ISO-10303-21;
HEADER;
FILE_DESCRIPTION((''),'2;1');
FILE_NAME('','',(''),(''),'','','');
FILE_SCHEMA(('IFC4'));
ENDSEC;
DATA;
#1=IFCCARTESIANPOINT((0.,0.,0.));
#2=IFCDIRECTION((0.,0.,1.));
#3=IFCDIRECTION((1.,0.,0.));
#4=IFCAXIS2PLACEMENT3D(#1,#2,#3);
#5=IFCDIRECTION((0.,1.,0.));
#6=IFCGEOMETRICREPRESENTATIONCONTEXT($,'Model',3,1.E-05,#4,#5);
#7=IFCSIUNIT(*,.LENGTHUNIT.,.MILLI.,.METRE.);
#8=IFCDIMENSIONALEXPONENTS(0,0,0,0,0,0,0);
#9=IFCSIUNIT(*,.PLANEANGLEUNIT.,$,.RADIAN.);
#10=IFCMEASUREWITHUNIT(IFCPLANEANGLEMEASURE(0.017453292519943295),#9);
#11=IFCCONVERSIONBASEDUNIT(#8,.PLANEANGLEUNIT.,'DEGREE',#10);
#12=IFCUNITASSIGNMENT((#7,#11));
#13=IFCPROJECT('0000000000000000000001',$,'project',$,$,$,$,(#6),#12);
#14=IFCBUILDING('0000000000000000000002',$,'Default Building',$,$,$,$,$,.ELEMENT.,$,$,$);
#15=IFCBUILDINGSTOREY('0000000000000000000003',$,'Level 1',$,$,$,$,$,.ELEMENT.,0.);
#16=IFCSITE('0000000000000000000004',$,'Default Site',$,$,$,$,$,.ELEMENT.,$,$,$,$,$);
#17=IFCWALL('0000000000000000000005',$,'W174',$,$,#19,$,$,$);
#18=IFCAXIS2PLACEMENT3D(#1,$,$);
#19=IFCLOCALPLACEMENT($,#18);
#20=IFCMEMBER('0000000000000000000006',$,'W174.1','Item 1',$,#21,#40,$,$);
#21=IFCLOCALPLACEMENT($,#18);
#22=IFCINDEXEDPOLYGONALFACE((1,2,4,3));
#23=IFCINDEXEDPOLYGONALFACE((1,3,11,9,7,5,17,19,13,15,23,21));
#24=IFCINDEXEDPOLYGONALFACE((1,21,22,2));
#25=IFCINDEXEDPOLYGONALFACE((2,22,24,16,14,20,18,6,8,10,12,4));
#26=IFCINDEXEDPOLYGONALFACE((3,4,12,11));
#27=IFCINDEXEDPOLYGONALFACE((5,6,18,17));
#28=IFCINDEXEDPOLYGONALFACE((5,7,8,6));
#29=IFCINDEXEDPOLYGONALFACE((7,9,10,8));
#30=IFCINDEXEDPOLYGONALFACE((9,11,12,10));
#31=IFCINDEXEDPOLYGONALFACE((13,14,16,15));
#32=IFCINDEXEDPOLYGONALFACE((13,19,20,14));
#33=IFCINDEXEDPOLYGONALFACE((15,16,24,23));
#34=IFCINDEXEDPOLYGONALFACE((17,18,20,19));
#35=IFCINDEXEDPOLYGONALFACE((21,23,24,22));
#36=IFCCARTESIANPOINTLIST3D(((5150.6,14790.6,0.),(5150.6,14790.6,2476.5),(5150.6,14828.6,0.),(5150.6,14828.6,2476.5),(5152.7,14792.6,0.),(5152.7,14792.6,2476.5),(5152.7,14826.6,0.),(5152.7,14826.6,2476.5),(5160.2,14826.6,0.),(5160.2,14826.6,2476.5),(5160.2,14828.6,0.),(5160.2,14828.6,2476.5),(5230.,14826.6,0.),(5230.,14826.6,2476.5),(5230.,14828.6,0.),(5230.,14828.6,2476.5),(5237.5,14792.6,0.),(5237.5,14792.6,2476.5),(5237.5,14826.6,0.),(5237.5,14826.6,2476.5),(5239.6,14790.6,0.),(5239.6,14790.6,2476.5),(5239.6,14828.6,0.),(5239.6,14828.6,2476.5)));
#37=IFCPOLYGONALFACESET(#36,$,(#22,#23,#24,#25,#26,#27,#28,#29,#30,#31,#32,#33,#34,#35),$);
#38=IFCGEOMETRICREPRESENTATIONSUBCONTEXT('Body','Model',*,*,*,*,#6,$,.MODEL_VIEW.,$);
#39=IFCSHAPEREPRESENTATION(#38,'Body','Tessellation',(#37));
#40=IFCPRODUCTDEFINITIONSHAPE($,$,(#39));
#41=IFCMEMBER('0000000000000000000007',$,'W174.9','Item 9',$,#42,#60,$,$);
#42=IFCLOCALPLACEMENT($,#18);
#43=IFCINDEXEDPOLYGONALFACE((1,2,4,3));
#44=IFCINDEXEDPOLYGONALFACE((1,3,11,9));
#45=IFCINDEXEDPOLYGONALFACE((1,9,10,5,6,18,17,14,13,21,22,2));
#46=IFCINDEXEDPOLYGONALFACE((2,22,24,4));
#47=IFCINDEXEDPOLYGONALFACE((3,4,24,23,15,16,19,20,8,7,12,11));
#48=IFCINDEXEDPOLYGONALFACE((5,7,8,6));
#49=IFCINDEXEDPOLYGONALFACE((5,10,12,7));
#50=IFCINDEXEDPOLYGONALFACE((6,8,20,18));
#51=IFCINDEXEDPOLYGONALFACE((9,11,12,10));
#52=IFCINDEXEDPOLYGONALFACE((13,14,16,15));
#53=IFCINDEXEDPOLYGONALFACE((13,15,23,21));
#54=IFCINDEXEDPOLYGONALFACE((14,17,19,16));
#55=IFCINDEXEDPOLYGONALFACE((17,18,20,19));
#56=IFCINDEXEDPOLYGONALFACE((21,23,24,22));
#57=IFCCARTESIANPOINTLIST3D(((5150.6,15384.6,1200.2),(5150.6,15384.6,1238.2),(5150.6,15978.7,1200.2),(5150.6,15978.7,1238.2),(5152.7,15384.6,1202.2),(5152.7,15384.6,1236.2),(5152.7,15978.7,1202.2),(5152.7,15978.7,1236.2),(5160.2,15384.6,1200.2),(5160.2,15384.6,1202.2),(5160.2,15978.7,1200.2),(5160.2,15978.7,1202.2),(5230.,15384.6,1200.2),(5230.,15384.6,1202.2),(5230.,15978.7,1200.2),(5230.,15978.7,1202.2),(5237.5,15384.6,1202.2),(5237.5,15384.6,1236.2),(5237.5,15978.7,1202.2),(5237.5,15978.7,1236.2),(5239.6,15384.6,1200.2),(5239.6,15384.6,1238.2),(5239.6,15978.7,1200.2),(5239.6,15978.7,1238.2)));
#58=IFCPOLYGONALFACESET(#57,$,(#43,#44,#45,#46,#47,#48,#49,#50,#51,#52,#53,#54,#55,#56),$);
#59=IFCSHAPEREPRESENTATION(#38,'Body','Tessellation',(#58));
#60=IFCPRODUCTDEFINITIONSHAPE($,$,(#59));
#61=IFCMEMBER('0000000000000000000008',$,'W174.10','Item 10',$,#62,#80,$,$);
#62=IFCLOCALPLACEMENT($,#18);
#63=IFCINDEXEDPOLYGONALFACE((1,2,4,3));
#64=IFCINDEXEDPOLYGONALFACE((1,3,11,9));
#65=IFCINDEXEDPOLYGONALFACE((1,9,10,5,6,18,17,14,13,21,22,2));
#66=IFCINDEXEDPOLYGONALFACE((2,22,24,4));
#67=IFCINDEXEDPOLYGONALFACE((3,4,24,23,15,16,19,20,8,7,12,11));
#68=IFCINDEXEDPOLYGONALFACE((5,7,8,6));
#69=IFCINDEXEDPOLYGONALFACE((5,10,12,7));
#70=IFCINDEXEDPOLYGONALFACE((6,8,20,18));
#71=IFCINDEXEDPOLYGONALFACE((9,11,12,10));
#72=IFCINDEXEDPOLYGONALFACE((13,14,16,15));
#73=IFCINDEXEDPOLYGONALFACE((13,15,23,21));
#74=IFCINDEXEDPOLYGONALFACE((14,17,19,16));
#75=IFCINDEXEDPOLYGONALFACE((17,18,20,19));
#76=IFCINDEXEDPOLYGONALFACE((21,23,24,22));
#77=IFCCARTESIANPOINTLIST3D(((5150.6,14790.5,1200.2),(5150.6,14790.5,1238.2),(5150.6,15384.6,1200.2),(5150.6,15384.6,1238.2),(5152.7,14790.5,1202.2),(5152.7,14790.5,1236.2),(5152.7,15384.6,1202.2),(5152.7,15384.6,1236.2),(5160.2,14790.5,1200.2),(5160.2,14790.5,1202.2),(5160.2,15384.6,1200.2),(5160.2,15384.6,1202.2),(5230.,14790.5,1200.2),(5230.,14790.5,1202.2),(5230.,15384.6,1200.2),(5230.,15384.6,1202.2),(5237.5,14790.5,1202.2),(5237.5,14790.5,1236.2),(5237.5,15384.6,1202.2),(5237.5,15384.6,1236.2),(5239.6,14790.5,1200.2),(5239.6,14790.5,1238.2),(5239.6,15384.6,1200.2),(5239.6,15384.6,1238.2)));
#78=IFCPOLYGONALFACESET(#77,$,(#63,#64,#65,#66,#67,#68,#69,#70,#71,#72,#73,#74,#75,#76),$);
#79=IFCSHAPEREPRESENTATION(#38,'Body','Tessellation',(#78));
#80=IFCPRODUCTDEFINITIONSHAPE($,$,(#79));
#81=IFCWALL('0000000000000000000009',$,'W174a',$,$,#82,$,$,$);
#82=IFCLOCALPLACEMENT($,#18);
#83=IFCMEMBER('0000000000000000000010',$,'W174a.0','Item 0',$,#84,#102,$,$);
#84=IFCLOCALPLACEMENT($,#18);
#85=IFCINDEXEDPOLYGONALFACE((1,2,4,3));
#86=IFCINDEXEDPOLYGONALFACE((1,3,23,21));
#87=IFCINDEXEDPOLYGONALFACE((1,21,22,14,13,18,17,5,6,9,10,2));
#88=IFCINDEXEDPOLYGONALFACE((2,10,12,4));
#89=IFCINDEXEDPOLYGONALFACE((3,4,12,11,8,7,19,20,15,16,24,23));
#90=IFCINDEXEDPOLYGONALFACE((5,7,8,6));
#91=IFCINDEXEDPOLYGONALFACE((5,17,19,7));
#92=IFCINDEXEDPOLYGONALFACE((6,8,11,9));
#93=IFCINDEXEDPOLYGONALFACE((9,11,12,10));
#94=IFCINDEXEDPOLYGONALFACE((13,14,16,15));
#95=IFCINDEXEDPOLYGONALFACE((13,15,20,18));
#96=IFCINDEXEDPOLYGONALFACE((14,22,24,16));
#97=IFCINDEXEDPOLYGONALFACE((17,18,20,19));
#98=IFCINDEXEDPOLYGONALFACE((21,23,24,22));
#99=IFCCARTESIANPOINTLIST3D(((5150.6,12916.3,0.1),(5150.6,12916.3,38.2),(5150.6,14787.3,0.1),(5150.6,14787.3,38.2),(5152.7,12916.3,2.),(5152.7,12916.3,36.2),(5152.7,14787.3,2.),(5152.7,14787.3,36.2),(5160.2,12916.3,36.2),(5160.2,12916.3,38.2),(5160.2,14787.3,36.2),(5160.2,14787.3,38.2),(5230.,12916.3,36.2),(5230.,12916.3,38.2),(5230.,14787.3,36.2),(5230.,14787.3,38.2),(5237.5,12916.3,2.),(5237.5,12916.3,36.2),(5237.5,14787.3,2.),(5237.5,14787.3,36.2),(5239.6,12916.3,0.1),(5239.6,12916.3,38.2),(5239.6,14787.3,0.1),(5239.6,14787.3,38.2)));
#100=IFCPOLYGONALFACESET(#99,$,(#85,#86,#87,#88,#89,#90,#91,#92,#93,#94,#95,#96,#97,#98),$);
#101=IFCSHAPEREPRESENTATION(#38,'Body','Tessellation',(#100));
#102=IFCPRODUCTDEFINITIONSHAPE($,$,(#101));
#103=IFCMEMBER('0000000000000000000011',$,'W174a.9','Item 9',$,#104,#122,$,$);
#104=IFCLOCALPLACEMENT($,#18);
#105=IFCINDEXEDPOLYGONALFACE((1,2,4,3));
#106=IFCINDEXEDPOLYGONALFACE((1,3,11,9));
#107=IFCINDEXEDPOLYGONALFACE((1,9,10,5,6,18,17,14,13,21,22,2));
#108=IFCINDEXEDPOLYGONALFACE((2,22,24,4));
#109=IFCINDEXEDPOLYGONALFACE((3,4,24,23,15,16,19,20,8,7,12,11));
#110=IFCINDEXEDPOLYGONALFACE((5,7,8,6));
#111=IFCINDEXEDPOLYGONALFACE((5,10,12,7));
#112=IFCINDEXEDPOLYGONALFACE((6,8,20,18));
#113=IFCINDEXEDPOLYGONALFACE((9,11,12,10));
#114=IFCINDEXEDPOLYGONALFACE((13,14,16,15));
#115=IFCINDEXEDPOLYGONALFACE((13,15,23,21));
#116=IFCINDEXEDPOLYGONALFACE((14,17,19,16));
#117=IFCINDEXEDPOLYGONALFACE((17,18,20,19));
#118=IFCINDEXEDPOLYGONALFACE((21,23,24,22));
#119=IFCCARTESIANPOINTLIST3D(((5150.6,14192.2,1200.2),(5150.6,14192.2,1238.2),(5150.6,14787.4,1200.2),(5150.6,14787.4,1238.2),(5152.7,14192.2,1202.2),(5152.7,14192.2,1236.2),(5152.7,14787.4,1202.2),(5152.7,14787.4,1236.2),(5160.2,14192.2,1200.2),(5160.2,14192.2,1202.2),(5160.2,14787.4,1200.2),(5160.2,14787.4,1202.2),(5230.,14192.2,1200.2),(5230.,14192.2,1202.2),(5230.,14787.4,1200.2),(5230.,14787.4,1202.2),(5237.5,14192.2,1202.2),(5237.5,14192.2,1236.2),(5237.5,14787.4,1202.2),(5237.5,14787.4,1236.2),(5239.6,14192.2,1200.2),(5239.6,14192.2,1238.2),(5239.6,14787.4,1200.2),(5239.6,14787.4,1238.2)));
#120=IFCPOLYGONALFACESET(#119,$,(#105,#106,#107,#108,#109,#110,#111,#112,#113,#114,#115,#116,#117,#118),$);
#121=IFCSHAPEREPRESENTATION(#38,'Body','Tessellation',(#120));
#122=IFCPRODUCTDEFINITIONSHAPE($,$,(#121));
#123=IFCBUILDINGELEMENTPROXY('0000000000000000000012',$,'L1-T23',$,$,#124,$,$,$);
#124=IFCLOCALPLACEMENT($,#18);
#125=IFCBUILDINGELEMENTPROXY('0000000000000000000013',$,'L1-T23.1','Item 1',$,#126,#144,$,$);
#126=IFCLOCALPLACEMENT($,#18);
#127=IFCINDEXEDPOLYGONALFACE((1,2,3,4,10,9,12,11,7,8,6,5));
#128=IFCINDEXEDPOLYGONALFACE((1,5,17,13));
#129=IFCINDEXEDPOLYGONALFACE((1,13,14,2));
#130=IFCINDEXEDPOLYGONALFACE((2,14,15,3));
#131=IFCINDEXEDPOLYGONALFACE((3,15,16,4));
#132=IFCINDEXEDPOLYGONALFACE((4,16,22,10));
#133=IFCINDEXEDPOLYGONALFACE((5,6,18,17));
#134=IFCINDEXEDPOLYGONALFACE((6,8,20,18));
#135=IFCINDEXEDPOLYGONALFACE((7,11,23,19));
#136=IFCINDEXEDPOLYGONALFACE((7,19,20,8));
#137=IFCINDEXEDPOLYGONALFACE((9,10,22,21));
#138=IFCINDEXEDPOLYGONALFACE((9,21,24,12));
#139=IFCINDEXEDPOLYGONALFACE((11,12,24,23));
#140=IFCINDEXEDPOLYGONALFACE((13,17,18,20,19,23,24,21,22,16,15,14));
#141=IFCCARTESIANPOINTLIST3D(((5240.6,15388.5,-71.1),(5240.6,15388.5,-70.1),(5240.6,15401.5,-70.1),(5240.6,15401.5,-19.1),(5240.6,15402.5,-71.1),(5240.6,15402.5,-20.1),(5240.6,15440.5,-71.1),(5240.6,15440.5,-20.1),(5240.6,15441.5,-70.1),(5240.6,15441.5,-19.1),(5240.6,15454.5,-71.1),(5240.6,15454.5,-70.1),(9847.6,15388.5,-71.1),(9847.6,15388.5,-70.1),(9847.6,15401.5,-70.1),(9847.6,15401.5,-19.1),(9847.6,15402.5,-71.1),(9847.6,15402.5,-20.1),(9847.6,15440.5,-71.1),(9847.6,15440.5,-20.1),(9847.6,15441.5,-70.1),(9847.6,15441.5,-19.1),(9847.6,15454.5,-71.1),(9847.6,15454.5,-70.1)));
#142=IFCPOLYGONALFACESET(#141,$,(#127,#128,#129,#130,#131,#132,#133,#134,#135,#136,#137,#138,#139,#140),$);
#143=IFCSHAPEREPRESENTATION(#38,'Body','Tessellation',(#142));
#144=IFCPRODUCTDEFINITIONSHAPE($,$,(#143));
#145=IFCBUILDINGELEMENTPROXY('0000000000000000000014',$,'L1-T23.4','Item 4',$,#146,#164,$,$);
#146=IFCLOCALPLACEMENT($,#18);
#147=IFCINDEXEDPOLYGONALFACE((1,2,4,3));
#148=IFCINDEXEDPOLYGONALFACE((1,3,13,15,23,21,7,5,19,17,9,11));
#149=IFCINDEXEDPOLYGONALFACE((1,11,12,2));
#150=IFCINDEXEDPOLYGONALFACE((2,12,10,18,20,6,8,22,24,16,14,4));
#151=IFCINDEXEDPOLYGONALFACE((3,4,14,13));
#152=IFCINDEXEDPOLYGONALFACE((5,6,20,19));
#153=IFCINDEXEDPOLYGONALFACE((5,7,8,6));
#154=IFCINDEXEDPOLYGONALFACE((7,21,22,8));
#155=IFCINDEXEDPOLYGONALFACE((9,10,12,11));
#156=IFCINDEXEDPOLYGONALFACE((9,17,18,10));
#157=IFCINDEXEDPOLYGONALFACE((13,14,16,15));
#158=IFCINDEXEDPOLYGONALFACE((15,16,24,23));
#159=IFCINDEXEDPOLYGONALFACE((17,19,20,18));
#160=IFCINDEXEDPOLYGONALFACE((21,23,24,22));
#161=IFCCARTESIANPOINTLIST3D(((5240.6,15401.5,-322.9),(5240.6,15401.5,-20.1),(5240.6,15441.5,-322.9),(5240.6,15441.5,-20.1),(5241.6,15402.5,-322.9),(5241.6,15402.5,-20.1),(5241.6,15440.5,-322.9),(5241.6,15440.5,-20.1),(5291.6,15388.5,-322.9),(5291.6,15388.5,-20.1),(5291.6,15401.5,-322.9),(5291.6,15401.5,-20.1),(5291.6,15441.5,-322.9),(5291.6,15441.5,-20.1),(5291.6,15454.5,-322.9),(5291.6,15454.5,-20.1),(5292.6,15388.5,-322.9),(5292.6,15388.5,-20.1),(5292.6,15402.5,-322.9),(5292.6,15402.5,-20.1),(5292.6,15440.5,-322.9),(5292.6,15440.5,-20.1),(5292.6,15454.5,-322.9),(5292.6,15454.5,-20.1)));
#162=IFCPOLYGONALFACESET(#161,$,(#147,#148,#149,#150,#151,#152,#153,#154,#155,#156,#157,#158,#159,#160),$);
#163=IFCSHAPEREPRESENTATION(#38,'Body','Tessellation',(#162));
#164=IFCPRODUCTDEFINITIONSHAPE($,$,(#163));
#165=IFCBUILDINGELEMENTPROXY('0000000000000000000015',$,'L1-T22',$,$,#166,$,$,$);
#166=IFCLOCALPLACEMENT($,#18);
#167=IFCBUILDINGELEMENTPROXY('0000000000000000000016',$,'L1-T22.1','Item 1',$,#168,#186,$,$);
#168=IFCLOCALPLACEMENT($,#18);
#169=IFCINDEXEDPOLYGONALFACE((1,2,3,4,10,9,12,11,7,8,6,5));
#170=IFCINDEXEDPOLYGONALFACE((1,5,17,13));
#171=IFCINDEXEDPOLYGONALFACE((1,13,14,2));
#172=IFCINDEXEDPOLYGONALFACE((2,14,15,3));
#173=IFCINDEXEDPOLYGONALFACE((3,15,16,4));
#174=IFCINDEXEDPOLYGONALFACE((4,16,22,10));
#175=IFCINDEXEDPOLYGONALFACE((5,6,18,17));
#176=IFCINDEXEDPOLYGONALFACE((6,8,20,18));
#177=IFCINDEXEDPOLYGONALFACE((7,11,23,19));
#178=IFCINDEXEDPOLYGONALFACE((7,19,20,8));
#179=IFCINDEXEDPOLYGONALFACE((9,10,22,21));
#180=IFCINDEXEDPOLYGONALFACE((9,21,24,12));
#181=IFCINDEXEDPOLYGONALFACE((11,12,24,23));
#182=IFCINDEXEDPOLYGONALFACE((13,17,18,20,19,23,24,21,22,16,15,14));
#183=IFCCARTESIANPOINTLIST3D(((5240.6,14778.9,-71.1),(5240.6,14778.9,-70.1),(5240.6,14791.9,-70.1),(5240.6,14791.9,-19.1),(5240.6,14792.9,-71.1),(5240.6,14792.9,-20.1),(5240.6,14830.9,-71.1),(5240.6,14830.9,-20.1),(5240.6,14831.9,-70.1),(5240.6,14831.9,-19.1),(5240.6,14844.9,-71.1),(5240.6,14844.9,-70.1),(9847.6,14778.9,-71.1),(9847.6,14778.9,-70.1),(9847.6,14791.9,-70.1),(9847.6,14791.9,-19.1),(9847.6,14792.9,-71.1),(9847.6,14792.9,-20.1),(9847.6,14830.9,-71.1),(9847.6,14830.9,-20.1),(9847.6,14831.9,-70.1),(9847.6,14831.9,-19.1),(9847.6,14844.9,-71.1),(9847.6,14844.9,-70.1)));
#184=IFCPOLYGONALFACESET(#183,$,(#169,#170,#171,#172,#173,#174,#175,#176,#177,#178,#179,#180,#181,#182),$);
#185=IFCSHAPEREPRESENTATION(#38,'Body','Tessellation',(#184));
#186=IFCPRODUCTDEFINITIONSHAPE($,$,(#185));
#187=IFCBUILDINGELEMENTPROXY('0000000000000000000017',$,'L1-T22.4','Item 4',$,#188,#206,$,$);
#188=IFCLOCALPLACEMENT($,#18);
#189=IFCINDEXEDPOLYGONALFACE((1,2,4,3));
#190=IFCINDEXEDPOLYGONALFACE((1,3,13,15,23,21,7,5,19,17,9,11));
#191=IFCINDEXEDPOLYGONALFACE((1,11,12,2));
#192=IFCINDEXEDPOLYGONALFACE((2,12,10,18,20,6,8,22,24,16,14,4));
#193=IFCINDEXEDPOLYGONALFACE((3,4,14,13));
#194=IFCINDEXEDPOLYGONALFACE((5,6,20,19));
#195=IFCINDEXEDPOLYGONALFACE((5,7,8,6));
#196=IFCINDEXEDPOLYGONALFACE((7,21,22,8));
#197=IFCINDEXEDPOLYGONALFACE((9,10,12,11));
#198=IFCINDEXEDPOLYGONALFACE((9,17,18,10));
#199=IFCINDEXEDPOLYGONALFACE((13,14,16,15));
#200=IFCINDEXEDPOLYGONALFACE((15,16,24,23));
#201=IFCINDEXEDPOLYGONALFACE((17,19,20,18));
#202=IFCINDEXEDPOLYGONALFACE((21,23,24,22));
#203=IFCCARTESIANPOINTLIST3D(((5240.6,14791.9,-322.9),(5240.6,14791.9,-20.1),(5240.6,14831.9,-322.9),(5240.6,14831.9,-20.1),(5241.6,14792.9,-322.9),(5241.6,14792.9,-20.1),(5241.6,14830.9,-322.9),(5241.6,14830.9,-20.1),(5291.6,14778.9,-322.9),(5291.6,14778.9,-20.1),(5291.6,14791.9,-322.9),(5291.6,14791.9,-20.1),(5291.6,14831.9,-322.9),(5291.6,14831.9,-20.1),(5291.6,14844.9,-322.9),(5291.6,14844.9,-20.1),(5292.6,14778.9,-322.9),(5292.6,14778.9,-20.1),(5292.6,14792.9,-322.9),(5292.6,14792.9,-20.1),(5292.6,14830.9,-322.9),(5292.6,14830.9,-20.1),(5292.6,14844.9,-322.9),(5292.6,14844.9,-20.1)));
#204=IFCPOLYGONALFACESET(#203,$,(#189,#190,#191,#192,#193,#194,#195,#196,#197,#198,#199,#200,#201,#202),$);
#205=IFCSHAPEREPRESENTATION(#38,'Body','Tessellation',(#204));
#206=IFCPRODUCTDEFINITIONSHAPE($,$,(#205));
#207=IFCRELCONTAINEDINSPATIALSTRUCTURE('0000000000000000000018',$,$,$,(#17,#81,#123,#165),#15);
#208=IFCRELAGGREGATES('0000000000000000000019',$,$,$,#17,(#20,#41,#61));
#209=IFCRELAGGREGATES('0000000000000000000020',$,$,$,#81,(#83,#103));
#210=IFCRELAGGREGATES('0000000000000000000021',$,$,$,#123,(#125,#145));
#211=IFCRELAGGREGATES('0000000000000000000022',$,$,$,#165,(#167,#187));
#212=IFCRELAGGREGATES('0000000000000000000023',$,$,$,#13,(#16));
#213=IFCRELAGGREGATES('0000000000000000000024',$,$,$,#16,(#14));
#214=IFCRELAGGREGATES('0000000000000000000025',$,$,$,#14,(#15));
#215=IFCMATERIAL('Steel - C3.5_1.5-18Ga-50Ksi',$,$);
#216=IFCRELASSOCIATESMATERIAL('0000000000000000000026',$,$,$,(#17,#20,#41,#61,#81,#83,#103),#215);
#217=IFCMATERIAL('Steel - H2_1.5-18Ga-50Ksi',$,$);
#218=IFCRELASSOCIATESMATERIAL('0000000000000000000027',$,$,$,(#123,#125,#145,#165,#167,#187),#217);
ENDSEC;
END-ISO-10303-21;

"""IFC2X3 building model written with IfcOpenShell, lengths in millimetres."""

from ifc_helpers import new_model, entity, si_unit, converted_unit, direction, frame, origin, origin_with_axes, origin_2d_with_axis, place, context, subcontext, project, spatial, polyline, c_section, outline, extrude, material, element, aggregate, save


model = new_model("IFC2X3")

# Units and contexts
model_context = context("Model", 3, precision=1e-05, world=origin_with_axes(), true_north=direction((0.0, 1.0, 0.0)))
body_context = subcontext(model_context, "Body", "Model", "MODEL_VIEW")
ifc_project = project(units=[si_unit("LENGTHUNIT", "METRE", prefix="MILLI"), converted_unit("PLANEANGLEUNIT", "DEGREE", entity("IfcPlaneAngleMeasure", 0.017453292519943295), si_unit("PLANEANGLEUNIT", "RADIAN"), dimensions=[0, 0, 0, 0, 0, 0, 0])], contexts=[model_context])

# Site, building, storey
site = spatial("IfcSite", under=ifc_project, Name="Default Site", CompositionType="ELEMENT")
building = spatial("IfcBuilding", under=site, Name="Default Building", CompositionType="ELEMENT")
storey = spatial("IfcBuildingStorey", under=building, Name="Level 1", CompositionType="ELEMENT", Elevation=0.0)

# Walls, members
ifc_material_1 = material(Name="Steel - C3.5_1.5-18Ga-50Ksi")
wall_1 = element("IfcWall", 1, inside=storey, material=ifc_material_1, Name="W174")
member_1_placement = place(None, frame((5195.1, 14809.6, 0.0), z_axis=(0.0, 0.0, 1.0), x_axis=(0.0, 1.0, 0.0)))
member_1 = element("IfcMember", 2, at=member_1_placement, material=ifc_material_1, Name="W174.1", Description="Item 1", context=body_context, shape_type="SweptSolid", body=[
    extrude(c_section(Depth=88.9, Width=38.1, WallThickness=2.0, Girth=9.5, at=origin_2d_with_axis()), origin(), (0.0, 0.0, 1.0), 2476.5),
])
member_2_placement = place(None, frame((5195.1, 15384.6, 1219.2), z_axis=(0.0, 1.0, 0.0), x_axis=(0.0, 0.0, -1.0)))
member_2 = element("IfcMember", 3, at=member_2_placement, material=ifc_material_1, Name="W174.9", Description="Item 9", context=body_context, shape_type="SweptSolid", body=[
    extrude(c_section(Depth=88.9, Width=38.1, WallThickness=2.0, Girth=9.5, at=origin_2d_with_axis()), origin(), (0.0, 0.0, 1.0), 594.1),
])
member_3_placement = place(None, frame((5195.1, 14790.5, 1219.2), z_axis=(0.0, 1.0, 0.0), x_axis=(0.0, 0.0, -1.0)))
member_3 = element("IfcMember", 4, at=member_3_placement, material=ifc_material_1, Name="W174.10", Description="Item 10", context=body_context, shape_type="SweptSolid", body=[
    extrude(c_section(Depth=88.9, Width=38.1, WallThickness=2.0, Girth=9.5, at=origin_2d_with_axis()), origin(), (0.0, 0.0, 1.0), 594.1),
])
aggregate(wall_1, [member_1, member_2, member_3])
wall_2 = element("IfcWall", 5, inside=storey, material=ifc_material_1, Name="W174a")
member_4_placement = place(None, frame((5195.1, 14787.3, 19.1), z_axis=(0.0, -1.0, 0.0), x_axis=(0.0, 0.0, 1.0)))
member_4 = element("IfcMember", 6, at=member_4_placement, material=ifc_material_1, Name="W174a.0", Description="Item 0", context=body_context, shape_type="SweptSolid", body=[
    extrude(c_section(Depth=88.9, Width=38.1, WallThickness=2.0, Girth=9.5, at=origin_2d_with_axis()), origin(), (0.0, 0.0, 1.0), 1871.0),
])
member_5_placement = place(None, frame((5195.1, 14192.2, 1219.2), z_axis=(0.0, 1.0, 0.0), x_axis=(0.0, 0.0, -1.0)))
member_5 = element("IfcMember", 7, at=member_5_placement, material=ifc_material_1, Name="W174a.9", Description="Item 9", context=body_context, shape_type="SweptSolid", body=[
    extrude(c_section(Depth=88.9, Width=38.1, WallThickness=2.0, Girth=9.5, at=origin_2d_with_axis()), origin(), (0.0, 0.0, 1.0), 595.2),
])
aggregate(wall_2, [member_4, member_5])

# Building element proxies
ifc_material_2 = material(Name="Steel - H2_1.5-18Ga-50Ksi")
proxy_1 = element("IfcBuildingElementProxy", 8, inside=storey, material=ifc_material_2, Name="L1-T23")
proxy_2_placement = place(None, frame((5240.6, 15388.5, -71.1), z_axis=(1.0, 0.0, 0.0), x_axis=(0.0, 40.0, 0.0)))
proxy_2 = element("IfcBuildingElementProxy", 9, at=proxy_2_placement, material=ifc_material_2, Name="L1-T23.1", Description="Item 1", context=body_context, shape_type="SweptSolid", body=[
    extrude(outline(polyline([(0.0, 0.0), (14.0, 0.0), (14.0, 51.0), (52.0, 51.0), (52.0, 0.0), (66.0, 0.0), (66.0, 1.0), (53.0, 1.0), (53.0, 52.0), (13.0, 52.0), (13.0, 1.0), (0.0, 1.0), (0.0, 0.0)])), origin(), (0.0, 0.0, 1.0), 4607.0),
])
proxy_3_placement = place(None, frame((5292.6, 15388.5, -322.9), z_axis=(0.0, 0.0, 1.0), x_axis=(0.0, 40.0, 0.0)))
proxy_3 = element("IfcBuildingElementProxy", 10, at=proxy_3_placement, material=ifc_material_2, Name="L1-T23.4", Description="Item 4", context=body_context, shape_type="SweptSolid", body=[
    extrude(outline(polyline([(0.0, 0.0), (14.0, 0.0), (14.0, 51.0), (52.0, 51.0), (52.0, 0.0), (66.0, 0.0), (66.0, 1.0), (53.0, 1.0), (53.0, 52.0), (13.0, 52.0), (13.0, 1.0), (0.0, 1.0), (0.0, 0.0)])), origin(), (0.0, 0.0, 1.0), 302.8),
])
aggregate(proxy_1, [proxy_2, proxy_3])
proxy_4 = element("IfcBuildingElementProxy", 11, inside=storey, material=ifc_material_2, Name="L1-T22")
proxy_5_placement = place(None, frame((5240.6, 14778.9, -71.1), z_axis=(1.0, 0.0, 0.0), x_axis=(0.0, 40.0, 0.0)))
proxy_5 = element("IfcBuildingElementProxy", 12, at=proxy_5_placement, material=ifc_material_2, Name="L1-T22.1", Description="Item 1", context=body_context, shape_type="SweptSolid", body=[
    extrude(outline(polyline([(0.0, 0.0), (14.0, 0.0), (14.0, 51.0), (52.0, 51.0), (52.0, 0.0), (66.0, 0.0), (66.0, 1.0), (53.0, 1.0), (53.0, 52.0), (13.0, 52.0), (13.0, 1.0), (0.0, 1.0), (0.0, 0.0)])), origin(), (0.0, 0.0, 1.0), 4607.0),
])
proxy_6_placement = place(None, frame((5292.6, 14778.9, -322.9), z_axis=(0.0, 0.0, 1.0), x_axis=(0.0, 40.0, 0.0)))
proxy_6 = element("IfcBuildingElementProxy", 13, at=proxy_6_placement, material=ifc_material_2, Name="L1-T22.4", Description="Item 4", context=body_context, shape_type="SweptSolid", body=[
    extrude(outline(polyline([(0.0, 0.0), (14.0, 0.0), (14.0, 51.0), (52.0, 51.0), (52.0, 0.0), (66.0, 0.0), (66.0, 1.0), (53.0, 1.0), (53.0, 52.0), (13.0, 52.0), (13.0, 1.0), (0.0, 1.0), (0.0, 0.0)])), origin(), (0.0, 0.0, 1.0), 302.8),
])
aggregate(proxy_4, [proxy_5, proxy_6])

save(model, "model.ifc")
